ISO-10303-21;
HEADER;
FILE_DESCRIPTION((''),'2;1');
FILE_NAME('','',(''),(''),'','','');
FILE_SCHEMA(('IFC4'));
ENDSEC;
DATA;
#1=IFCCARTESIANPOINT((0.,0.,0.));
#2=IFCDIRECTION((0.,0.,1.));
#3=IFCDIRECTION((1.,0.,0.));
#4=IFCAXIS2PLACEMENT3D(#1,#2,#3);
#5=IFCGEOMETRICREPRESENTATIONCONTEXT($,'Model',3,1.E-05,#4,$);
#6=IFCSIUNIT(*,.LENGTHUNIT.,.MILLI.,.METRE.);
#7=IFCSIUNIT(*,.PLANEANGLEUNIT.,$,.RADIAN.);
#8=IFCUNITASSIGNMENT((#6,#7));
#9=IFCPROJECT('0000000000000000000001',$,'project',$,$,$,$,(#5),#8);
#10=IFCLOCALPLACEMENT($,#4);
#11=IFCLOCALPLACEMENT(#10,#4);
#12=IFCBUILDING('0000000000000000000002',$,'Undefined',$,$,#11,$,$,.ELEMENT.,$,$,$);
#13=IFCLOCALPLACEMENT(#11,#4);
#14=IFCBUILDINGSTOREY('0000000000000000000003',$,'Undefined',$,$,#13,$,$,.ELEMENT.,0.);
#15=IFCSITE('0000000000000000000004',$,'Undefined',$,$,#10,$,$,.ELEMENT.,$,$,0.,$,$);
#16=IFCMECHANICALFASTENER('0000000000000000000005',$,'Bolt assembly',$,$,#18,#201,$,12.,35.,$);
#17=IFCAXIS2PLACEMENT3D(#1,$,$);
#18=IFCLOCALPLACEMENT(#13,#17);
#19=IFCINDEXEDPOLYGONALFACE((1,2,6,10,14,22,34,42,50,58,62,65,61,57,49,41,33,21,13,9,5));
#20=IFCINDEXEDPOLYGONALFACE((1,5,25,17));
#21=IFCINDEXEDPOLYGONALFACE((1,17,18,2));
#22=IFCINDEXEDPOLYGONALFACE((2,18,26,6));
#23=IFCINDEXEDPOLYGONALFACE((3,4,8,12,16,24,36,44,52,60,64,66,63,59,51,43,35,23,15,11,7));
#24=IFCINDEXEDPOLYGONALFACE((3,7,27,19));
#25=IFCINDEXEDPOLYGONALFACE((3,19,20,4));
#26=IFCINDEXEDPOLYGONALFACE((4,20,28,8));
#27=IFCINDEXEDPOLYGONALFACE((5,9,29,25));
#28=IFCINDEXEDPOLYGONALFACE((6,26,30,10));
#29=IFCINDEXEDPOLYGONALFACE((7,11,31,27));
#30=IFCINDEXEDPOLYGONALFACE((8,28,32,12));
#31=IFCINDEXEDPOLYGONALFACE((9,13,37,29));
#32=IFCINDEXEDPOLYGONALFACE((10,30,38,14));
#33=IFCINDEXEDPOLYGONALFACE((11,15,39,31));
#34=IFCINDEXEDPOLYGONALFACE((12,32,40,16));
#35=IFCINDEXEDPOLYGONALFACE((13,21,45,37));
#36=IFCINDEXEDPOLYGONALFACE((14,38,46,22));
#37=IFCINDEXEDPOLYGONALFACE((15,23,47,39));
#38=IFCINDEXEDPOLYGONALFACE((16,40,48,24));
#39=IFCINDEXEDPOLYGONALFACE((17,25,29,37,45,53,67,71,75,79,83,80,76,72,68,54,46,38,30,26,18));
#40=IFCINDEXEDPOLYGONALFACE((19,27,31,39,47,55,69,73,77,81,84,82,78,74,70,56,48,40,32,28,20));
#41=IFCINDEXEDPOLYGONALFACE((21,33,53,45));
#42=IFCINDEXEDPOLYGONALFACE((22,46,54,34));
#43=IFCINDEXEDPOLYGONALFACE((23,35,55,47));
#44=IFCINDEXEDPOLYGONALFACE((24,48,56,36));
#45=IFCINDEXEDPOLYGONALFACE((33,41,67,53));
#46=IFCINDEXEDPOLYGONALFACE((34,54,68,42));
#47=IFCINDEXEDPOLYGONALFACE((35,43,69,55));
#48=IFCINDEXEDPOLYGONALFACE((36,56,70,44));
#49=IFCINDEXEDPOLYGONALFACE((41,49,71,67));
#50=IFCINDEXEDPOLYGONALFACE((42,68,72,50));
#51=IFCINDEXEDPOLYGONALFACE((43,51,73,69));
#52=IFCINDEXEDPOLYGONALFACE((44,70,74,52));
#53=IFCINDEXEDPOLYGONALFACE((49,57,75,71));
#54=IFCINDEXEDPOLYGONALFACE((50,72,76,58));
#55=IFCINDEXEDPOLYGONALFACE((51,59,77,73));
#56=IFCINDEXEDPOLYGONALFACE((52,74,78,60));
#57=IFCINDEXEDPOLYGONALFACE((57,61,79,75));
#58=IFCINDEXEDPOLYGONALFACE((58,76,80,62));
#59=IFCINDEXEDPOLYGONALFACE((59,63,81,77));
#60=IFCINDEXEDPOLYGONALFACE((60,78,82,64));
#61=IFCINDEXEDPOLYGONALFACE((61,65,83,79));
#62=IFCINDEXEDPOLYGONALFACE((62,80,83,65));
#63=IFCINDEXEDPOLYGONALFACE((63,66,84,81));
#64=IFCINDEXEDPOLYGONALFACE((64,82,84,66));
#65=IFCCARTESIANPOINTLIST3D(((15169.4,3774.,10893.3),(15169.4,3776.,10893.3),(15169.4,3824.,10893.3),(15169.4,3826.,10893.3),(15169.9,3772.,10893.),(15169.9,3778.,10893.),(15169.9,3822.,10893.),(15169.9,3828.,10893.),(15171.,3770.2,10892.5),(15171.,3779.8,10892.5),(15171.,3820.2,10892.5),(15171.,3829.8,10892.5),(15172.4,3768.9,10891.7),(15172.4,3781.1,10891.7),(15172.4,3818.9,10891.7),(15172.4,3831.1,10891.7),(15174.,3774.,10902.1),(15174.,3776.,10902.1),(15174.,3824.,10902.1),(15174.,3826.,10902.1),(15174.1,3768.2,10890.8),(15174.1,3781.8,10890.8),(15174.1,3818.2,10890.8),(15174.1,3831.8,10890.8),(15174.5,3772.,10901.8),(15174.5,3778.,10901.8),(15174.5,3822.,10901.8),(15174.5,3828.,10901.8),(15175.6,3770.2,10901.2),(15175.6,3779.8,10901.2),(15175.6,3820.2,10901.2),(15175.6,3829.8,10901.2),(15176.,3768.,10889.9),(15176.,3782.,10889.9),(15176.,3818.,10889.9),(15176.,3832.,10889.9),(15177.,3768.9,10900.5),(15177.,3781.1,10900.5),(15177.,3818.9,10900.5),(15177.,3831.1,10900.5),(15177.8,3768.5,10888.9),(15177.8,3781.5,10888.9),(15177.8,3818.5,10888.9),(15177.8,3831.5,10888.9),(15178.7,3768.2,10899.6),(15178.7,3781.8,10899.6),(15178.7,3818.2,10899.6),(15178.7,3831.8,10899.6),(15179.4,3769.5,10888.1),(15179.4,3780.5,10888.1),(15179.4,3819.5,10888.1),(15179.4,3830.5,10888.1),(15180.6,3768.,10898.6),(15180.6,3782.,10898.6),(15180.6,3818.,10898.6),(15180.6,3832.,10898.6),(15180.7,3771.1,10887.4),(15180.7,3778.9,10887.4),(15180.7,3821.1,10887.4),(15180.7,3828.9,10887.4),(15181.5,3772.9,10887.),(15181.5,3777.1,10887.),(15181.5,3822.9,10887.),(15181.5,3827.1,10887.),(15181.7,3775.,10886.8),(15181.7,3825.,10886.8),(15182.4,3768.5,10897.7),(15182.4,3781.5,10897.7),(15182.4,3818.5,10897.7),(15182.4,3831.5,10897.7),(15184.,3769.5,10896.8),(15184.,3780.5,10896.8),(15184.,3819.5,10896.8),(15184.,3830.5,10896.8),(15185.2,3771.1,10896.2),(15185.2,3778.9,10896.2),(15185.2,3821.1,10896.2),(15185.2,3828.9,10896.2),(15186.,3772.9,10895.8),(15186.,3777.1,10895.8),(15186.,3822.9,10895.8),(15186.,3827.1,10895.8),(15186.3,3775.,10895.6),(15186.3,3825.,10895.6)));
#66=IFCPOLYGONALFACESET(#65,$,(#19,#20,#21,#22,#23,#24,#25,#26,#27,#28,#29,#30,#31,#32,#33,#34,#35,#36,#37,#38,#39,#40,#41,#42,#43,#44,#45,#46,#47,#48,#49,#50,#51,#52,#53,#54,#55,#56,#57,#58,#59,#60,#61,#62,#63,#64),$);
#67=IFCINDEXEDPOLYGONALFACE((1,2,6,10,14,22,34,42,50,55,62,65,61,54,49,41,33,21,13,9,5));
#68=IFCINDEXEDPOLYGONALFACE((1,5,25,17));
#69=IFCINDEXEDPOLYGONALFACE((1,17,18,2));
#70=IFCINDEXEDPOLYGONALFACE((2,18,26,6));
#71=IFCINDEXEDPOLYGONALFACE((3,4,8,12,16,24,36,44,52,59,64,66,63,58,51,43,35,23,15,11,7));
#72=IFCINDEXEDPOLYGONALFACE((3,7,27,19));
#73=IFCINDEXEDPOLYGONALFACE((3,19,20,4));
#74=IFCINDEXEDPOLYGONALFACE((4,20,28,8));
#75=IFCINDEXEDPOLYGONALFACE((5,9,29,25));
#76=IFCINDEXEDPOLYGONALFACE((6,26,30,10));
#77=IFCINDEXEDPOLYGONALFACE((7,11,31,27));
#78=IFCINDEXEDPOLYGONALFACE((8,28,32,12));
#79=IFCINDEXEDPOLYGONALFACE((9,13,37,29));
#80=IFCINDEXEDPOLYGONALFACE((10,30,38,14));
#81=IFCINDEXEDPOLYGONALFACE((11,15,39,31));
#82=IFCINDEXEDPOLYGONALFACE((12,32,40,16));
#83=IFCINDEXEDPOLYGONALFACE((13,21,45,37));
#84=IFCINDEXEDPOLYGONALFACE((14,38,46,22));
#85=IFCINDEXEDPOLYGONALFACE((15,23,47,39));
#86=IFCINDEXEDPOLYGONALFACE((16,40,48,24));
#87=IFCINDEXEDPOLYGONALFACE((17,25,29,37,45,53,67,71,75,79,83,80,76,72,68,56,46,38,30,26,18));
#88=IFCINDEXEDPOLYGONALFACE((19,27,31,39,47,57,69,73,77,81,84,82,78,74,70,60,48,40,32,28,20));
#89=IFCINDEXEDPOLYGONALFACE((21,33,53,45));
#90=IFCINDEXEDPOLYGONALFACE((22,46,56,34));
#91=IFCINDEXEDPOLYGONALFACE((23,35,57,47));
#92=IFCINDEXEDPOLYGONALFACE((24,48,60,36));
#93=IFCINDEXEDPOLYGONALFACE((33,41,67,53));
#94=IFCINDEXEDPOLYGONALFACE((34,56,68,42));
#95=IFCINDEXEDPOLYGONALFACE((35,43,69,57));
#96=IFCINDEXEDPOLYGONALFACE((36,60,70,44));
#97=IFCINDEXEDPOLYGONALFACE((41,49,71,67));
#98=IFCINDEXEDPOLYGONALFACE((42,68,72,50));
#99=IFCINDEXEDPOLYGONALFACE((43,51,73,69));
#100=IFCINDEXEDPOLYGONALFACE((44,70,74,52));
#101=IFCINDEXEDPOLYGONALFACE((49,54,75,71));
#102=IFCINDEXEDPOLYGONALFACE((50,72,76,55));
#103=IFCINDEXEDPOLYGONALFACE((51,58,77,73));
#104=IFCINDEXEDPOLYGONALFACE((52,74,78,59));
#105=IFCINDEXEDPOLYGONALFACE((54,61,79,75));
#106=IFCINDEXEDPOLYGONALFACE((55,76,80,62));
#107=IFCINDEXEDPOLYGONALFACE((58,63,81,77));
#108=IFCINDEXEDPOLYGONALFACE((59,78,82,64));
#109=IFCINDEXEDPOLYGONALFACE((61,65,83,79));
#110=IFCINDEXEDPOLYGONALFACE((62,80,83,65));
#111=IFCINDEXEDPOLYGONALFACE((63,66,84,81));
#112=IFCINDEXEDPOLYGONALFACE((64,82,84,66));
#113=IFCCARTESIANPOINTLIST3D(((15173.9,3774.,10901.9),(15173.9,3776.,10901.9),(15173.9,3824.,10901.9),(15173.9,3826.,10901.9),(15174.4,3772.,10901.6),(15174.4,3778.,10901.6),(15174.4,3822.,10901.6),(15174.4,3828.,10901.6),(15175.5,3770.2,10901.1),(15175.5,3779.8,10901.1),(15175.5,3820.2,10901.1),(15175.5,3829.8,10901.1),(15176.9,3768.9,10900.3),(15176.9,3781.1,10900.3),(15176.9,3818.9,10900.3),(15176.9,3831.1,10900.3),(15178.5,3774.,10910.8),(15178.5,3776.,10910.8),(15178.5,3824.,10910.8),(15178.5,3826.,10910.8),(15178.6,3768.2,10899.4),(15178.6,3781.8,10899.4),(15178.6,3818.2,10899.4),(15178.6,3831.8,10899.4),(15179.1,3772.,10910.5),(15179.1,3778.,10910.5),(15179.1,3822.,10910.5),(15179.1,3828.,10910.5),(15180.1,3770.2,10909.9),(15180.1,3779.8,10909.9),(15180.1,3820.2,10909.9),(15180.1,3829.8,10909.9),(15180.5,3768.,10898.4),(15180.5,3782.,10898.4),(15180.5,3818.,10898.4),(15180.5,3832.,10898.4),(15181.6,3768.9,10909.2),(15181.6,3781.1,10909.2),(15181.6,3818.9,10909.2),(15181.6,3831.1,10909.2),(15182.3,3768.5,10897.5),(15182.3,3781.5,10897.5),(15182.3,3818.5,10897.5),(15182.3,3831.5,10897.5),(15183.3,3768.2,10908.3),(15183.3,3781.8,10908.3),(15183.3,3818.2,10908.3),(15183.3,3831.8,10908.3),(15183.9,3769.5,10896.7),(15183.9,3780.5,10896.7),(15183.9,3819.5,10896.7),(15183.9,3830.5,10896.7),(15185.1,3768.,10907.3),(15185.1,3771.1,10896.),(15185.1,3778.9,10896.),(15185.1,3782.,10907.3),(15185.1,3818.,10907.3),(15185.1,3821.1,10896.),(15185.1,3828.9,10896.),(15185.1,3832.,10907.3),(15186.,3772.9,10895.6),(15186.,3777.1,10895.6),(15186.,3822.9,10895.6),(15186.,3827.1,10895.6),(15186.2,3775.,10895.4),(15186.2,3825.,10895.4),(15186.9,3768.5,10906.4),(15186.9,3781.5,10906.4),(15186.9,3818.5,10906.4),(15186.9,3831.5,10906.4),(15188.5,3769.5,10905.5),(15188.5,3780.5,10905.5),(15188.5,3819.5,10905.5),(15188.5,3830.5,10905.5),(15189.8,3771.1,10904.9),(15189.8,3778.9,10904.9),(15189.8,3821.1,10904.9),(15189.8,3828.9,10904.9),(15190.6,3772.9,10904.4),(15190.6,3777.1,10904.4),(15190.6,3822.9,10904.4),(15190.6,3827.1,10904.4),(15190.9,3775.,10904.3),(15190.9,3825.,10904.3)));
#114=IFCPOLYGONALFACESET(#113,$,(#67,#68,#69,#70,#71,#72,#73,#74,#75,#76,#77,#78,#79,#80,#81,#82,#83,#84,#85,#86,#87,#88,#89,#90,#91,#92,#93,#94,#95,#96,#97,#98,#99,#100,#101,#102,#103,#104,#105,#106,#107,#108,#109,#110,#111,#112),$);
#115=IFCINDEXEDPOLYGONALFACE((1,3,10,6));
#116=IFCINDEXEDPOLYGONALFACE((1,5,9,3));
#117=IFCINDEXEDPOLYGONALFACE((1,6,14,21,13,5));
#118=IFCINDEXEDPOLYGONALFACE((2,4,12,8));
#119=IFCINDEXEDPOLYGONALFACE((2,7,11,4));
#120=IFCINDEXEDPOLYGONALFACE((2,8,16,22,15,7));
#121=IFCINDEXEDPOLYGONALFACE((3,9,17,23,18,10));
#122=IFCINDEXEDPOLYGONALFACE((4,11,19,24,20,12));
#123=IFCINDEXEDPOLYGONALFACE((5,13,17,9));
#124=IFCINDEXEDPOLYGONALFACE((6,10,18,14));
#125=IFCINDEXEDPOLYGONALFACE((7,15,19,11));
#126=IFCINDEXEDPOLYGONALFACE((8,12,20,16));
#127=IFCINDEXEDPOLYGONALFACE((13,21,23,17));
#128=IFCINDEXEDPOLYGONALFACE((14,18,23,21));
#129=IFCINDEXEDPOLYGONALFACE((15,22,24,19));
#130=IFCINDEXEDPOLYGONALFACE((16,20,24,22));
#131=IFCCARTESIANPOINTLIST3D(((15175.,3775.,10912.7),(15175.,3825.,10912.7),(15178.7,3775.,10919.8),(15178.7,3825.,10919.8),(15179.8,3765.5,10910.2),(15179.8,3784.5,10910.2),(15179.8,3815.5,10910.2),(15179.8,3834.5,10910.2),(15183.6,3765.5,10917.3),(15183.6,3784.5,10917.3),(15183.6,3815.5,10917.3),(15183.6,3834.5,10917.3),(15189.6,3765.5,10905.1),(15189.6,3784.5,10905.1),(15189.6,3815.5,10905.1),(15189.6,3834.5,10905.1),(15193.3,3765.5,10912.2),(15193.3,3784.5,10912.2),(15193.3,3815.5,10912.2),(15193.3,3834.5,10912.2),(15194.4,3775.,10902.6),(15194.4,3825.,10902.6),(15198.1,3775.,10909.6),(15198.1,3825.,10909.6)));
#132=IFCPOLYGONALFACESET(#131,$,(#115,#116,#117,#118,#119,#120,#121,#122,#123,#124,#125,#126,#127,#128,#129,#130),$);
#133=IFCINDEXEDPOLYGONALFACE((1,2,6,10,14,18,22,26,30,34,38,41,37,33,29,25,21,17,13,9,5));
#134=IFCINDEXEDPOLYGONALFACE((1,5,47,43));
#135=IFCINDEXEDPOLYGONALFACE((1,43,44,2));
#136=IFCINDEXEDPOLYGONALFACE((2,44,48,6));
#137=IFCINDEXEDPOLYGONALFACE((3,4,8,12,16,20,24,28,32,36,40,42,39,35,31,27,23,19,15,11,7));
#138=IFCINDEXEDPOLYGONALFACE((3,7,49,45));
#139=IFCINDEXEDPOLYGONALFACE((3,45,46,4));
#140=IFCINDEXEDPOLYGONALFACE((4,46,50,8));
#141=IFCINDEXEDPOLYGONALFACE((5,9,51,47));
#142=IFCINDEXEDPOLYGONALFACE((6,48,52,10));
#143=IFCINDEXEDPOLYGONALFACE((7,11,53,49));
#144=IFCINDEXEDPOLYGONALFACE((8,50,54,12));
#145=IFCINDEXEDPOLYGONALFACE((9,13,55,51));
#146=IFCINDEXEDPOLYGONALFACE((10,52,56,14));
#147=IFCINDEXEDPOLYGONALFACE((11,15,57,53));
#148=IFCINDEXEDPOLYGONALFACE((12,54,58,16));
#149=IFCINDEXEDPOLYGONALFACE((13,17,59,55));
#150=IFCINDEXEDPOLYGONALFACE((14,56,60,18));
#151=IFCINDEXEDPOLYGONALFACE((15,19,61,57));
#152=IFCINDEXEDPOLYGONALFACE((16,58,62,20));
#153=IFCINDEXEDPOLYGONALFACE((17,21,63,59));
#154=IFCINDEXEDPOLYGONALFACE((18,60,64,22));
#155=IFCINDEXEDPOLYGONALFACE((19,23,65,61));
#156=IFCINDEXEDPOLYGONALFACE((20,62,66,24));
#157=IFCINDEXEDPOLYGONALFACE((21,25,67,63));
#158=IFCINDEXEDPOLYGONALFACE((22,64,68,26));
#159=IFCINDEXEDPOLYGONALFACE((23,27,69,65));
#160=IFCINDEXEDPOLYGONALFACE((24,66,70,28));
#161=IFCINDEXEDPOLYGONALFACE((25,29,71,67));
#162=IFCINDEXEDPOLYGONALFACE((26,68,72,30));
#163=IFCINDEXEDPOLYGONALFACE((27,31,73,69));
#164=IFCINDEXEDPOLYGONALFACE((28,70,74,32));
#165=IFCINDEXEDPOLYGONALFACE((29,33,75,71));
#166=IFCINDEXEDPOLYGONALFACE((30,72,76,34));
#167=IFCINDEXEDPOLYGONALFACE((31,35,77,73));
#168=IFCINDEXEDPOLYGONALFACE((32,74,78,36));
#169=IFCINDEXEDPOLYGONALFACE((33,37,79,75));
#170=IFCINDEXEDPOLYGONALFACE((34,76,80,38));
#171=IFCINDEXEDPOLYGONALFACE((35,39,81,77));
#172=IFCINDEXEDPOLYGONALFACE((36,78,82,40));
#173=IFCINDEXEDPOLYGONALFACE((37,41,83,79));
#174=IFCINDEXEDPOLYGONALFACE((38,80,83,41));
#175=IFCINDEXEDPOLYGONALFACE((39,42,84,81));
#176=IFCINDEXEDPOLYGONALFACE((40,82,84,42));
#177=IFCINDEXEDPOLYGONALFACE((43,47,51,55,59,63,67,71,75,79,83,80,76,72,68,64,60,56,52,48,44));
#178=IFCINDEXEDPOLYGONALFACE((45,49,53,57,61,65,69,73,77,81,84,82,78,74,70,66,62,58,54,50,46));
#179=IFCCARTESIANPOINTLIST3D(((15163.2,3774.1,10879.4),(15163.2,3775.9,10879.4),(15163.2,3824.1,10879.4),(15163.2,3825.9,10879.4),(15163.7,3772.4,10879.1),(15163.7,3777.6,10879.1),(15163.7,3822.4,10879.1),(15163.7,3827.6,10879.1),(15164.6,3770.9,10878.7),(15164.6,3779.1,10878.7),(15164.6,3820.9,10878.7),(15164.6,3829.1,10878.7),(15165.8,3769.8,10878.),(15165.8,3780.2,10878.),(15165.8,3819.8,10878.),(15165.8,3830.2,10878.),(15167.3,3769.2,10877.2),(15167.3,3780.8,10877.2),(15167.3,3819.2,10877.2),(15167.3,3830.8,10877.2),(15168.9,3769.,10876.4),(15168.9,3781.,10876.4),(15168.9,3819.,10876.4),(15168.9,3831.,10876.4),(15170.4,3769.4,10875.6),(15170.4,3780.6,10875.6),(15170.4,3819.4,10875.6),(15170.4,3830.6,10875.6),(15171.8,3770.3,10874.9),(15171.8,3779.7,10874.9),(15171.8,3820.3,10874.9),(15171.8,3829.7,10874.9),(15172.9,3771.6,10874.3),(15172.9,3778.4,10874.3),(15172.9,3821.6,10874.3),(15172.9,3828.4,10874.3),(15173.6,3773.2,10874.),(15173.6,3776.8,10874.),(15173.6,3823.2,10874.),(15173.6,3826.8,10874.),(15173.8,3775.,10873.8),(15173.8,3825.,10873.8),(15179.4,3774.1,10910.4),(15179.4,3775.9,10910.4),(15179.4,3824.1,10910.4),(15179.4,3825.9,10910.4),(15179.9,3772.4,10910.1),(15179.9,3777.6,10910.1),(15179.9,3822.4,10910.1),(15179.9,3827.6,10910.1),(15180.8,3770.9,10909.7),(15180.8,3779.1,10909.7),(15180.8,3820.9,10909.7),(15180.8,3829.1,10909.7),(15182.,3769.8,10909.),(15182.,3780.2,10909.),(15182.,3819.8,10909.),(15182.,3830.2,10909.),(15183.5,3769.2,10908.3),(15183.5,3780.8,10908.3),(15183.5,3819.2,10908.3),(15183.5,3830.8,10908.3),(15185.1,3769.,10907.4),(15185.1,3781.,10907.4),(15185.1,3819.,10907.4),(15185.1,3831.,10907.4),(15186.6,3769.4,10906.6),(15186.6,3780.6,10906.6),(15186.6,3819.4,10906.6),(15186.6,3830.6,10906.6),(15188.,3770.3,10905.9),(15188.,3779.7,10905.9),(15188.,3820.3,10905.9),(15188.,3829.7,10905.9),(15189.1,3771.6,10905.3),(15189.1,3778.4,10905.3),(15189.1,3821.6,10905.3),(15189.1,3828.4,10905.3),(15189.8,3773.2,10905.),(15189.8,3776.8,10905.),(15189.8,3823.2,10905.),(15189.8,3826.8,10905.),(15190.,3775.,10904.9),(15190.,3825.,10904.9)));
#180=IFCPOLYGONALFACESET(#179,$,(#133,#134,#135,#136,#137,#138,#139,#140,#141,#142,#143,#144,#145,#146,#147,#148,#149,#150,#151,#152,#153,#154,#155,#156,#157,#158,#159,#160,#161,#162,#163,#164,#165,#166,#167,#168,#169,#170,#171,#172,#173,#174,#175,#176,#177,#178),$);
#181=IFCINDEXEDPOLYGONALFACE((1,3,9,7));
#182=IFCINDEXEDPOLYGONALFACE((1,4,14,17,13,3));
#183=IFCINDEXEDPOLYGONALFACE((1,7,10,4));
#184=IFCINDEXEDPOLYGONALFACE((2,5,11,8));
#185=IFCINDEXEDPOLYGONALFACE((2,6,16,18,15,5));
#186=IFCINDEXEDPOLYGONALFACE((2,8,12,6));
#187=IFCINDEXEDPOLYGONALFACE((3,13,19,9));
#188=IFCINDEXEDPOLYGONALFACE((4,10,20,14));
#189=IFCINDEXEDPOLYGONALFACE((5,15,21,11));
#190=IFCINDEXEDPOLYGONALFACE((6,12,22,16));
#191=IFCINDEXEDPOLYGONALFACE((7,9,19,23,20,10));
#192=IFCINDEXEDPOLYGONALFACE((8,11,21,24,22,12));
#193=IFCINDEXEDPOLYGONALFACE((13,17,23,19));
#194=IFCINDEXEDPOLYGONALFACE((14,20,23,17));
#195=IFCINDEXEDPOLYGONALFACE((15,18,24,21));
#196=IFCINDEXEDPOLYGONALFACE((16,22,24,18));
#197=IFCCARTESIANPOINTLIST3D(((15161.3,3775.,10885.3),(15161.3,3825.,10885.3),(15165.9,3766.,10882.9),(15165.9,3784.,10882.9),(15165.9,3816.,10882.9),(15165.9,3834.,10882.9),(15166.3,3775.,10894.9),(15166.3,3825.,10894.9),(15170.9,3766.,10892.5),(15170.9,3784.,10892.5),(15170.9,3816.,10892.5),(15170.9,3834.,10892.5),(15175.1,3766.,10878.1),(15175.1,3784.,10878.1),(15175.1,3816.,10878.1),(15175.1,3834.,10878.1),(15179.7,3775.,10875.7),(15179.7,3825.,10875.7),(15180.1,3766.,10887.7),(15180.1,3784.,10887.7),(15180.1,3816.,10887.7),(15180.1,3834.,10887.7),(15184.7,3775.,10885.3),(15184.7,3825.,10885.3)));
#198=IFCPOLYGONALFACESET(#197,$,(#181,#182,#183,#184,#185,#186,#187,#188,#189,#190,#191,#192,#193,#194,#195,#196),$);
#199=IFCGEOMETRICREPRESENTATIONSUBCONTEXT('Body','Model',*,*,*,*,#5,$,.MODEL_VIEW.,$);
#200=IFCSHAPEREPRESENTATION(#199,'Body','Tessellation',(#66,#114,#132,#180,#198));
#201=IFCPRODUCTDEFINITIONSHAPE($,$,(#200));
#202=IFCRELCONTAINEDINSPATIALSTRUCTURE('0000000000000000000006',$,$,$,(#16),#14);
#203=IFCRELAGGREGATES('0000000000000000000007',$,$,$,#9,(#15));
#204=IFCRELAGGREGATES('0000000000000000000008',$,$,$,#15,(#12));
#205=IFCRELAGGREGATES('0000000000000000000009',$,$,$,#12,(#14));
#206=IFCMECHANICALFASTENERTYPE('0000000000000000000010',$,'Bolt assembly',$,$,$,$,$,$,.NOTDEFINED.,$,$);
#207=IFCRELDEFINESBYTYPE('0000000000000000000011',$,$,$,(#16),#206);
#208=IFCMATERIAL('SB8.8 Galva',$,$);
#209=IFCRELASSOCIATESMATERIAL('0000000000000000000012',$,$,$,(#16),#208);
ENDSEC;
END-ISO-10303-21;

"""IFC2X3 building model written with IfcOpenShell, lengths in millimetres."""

from ifc_helpers import new_model, si_unit, frame, origin_with_axes, origin_2d_with_axis, place, context, subcontext, project, spatial, polyline, circle, outline, extrude, source, transform, mapped, material, type_object, element, save


model = new_model("IFC2X3")

# Units and contexts
model_context = context("Model", 3, precision=1e-05, world=origin_with_axes())
body_context = subcontext(model_context, "Body", "Model", "MODEL_VIEW")
ifc_project = project(units=[si_unit("LENGTHUNIT", "METRE", prefix="MILLI"), si_unit("PLANEANGLEUNIT", "RADIAN")], contexts=[model_context])

# Site, building, storey
site_placement = place(None, origin_with_axes())
site = spatial("IfcSite", under=ifc_project, at=site_placement, Name="Undefined", CompositionType="ELEMENT", RefElevation=0.0)
building_placement = place(site_placement, origin_with_axes())
building = spatial("IfcBuilding", under=site, at=building_placement, Name="Undefined", CompositionType="ELEMENT")
storey_placement = place(building_placement, origin_with_axes())
storey = spatial("IfcBuildingStorey", under=building, at=storey_placement, Name="Undefined", CompositionType="ELEMENT", Elevation=0.0)

# Mechanical fastener
ifc_material_1 = material(Name="SB8.8 Galva")
mechanical_fastener_type = type_object("IfcMechanicalFastenerType", Name="Bolt assembly")
shared_shape_1 = source(origin_with_axes(), body_context, "Body", "SweptSolid", [
    extrude(circle(Radius=7.0, at=origin_2d_with_axis()), frame((0.0, -0.1, 0.0), z_axis=(0.0, 1.0, 0.0), x_axis=(1.0, 0.0, 0.0)), (0.0, 0.0, 1.0), 9.9),
    extrude(circle(Radius=7.0, at=origin_2d_with_axis()), frame((0.0, -9.9, 0.0), z_axis=(0.0, 1.0, 0.0), x_axis=(1.0, 0.0, 0.0)), (0.0, 0.0, 1.0), 10.0),
    extrude(outline(polyline([(11.0, 0.0), (5.5, 9.5), (-5.5, 9.5), (-11.0, 0.0), (-5.5, -9.5), (5.5, -9.5), (11.0, 0.0)])), frame((0.0, -18.0, 0.0), z_axis=(0.0, 1.0, 0.0), x_axis=(1.0, 0.0, 0.0)), (0.0, 0.0, 1.0), 8.0),
    extrude(circle(Radius=6.0, at=origin_2d_with_axis()), frame((0.0, -10.0, 0.0), z_axis=(0.0, 1.0, 0.0), x_axis=(1.0, 0.0, 0.0)), (0.0, 0.0, 1.0), 35.0),
    extrude(outline(polyline([(10.4, 0.0), (5.2, 9.0), (-5.2, 9.0), (-10.4, 0.0), (-5.2, -9.0), (5.2, -9.0), (10.4, 0.0)])), frame((0.0, 9.8, 0.0), z_axis=(0.0, 1.0, 0.0), x_axis=(1.0, 0.0, 0.0)), (0.0, 0.0, 1.0), 10.8),
])
for number, where, z_axis, x_axis, name in (
    (1, (15180.1, 3800.0, 10898.8), (0.0, 1.0, 0.0), (0.886082, 0.0, -0.463529), "Bolt assembly"),
):
    element("IfcMechanicalFastener", number, at=place(storey_placement, frame(where, z_axis=z_axis, x_axis=x_axis)), inside=storey, type_object=mechanical_fastener_type, material=ifc_material_1, Name=name, NominalDiameter=12.0, NominalLength=35.0, context=body_context, shape_type="MappedRepresentation", body=[
        mapped(shared_shape_1, transform((0.0, 0.0, -25.0))),
        mapped(shared_shape_1, transform((0.0, 0.0, 25.0))),
    ])

save(model, "model.ifc")
